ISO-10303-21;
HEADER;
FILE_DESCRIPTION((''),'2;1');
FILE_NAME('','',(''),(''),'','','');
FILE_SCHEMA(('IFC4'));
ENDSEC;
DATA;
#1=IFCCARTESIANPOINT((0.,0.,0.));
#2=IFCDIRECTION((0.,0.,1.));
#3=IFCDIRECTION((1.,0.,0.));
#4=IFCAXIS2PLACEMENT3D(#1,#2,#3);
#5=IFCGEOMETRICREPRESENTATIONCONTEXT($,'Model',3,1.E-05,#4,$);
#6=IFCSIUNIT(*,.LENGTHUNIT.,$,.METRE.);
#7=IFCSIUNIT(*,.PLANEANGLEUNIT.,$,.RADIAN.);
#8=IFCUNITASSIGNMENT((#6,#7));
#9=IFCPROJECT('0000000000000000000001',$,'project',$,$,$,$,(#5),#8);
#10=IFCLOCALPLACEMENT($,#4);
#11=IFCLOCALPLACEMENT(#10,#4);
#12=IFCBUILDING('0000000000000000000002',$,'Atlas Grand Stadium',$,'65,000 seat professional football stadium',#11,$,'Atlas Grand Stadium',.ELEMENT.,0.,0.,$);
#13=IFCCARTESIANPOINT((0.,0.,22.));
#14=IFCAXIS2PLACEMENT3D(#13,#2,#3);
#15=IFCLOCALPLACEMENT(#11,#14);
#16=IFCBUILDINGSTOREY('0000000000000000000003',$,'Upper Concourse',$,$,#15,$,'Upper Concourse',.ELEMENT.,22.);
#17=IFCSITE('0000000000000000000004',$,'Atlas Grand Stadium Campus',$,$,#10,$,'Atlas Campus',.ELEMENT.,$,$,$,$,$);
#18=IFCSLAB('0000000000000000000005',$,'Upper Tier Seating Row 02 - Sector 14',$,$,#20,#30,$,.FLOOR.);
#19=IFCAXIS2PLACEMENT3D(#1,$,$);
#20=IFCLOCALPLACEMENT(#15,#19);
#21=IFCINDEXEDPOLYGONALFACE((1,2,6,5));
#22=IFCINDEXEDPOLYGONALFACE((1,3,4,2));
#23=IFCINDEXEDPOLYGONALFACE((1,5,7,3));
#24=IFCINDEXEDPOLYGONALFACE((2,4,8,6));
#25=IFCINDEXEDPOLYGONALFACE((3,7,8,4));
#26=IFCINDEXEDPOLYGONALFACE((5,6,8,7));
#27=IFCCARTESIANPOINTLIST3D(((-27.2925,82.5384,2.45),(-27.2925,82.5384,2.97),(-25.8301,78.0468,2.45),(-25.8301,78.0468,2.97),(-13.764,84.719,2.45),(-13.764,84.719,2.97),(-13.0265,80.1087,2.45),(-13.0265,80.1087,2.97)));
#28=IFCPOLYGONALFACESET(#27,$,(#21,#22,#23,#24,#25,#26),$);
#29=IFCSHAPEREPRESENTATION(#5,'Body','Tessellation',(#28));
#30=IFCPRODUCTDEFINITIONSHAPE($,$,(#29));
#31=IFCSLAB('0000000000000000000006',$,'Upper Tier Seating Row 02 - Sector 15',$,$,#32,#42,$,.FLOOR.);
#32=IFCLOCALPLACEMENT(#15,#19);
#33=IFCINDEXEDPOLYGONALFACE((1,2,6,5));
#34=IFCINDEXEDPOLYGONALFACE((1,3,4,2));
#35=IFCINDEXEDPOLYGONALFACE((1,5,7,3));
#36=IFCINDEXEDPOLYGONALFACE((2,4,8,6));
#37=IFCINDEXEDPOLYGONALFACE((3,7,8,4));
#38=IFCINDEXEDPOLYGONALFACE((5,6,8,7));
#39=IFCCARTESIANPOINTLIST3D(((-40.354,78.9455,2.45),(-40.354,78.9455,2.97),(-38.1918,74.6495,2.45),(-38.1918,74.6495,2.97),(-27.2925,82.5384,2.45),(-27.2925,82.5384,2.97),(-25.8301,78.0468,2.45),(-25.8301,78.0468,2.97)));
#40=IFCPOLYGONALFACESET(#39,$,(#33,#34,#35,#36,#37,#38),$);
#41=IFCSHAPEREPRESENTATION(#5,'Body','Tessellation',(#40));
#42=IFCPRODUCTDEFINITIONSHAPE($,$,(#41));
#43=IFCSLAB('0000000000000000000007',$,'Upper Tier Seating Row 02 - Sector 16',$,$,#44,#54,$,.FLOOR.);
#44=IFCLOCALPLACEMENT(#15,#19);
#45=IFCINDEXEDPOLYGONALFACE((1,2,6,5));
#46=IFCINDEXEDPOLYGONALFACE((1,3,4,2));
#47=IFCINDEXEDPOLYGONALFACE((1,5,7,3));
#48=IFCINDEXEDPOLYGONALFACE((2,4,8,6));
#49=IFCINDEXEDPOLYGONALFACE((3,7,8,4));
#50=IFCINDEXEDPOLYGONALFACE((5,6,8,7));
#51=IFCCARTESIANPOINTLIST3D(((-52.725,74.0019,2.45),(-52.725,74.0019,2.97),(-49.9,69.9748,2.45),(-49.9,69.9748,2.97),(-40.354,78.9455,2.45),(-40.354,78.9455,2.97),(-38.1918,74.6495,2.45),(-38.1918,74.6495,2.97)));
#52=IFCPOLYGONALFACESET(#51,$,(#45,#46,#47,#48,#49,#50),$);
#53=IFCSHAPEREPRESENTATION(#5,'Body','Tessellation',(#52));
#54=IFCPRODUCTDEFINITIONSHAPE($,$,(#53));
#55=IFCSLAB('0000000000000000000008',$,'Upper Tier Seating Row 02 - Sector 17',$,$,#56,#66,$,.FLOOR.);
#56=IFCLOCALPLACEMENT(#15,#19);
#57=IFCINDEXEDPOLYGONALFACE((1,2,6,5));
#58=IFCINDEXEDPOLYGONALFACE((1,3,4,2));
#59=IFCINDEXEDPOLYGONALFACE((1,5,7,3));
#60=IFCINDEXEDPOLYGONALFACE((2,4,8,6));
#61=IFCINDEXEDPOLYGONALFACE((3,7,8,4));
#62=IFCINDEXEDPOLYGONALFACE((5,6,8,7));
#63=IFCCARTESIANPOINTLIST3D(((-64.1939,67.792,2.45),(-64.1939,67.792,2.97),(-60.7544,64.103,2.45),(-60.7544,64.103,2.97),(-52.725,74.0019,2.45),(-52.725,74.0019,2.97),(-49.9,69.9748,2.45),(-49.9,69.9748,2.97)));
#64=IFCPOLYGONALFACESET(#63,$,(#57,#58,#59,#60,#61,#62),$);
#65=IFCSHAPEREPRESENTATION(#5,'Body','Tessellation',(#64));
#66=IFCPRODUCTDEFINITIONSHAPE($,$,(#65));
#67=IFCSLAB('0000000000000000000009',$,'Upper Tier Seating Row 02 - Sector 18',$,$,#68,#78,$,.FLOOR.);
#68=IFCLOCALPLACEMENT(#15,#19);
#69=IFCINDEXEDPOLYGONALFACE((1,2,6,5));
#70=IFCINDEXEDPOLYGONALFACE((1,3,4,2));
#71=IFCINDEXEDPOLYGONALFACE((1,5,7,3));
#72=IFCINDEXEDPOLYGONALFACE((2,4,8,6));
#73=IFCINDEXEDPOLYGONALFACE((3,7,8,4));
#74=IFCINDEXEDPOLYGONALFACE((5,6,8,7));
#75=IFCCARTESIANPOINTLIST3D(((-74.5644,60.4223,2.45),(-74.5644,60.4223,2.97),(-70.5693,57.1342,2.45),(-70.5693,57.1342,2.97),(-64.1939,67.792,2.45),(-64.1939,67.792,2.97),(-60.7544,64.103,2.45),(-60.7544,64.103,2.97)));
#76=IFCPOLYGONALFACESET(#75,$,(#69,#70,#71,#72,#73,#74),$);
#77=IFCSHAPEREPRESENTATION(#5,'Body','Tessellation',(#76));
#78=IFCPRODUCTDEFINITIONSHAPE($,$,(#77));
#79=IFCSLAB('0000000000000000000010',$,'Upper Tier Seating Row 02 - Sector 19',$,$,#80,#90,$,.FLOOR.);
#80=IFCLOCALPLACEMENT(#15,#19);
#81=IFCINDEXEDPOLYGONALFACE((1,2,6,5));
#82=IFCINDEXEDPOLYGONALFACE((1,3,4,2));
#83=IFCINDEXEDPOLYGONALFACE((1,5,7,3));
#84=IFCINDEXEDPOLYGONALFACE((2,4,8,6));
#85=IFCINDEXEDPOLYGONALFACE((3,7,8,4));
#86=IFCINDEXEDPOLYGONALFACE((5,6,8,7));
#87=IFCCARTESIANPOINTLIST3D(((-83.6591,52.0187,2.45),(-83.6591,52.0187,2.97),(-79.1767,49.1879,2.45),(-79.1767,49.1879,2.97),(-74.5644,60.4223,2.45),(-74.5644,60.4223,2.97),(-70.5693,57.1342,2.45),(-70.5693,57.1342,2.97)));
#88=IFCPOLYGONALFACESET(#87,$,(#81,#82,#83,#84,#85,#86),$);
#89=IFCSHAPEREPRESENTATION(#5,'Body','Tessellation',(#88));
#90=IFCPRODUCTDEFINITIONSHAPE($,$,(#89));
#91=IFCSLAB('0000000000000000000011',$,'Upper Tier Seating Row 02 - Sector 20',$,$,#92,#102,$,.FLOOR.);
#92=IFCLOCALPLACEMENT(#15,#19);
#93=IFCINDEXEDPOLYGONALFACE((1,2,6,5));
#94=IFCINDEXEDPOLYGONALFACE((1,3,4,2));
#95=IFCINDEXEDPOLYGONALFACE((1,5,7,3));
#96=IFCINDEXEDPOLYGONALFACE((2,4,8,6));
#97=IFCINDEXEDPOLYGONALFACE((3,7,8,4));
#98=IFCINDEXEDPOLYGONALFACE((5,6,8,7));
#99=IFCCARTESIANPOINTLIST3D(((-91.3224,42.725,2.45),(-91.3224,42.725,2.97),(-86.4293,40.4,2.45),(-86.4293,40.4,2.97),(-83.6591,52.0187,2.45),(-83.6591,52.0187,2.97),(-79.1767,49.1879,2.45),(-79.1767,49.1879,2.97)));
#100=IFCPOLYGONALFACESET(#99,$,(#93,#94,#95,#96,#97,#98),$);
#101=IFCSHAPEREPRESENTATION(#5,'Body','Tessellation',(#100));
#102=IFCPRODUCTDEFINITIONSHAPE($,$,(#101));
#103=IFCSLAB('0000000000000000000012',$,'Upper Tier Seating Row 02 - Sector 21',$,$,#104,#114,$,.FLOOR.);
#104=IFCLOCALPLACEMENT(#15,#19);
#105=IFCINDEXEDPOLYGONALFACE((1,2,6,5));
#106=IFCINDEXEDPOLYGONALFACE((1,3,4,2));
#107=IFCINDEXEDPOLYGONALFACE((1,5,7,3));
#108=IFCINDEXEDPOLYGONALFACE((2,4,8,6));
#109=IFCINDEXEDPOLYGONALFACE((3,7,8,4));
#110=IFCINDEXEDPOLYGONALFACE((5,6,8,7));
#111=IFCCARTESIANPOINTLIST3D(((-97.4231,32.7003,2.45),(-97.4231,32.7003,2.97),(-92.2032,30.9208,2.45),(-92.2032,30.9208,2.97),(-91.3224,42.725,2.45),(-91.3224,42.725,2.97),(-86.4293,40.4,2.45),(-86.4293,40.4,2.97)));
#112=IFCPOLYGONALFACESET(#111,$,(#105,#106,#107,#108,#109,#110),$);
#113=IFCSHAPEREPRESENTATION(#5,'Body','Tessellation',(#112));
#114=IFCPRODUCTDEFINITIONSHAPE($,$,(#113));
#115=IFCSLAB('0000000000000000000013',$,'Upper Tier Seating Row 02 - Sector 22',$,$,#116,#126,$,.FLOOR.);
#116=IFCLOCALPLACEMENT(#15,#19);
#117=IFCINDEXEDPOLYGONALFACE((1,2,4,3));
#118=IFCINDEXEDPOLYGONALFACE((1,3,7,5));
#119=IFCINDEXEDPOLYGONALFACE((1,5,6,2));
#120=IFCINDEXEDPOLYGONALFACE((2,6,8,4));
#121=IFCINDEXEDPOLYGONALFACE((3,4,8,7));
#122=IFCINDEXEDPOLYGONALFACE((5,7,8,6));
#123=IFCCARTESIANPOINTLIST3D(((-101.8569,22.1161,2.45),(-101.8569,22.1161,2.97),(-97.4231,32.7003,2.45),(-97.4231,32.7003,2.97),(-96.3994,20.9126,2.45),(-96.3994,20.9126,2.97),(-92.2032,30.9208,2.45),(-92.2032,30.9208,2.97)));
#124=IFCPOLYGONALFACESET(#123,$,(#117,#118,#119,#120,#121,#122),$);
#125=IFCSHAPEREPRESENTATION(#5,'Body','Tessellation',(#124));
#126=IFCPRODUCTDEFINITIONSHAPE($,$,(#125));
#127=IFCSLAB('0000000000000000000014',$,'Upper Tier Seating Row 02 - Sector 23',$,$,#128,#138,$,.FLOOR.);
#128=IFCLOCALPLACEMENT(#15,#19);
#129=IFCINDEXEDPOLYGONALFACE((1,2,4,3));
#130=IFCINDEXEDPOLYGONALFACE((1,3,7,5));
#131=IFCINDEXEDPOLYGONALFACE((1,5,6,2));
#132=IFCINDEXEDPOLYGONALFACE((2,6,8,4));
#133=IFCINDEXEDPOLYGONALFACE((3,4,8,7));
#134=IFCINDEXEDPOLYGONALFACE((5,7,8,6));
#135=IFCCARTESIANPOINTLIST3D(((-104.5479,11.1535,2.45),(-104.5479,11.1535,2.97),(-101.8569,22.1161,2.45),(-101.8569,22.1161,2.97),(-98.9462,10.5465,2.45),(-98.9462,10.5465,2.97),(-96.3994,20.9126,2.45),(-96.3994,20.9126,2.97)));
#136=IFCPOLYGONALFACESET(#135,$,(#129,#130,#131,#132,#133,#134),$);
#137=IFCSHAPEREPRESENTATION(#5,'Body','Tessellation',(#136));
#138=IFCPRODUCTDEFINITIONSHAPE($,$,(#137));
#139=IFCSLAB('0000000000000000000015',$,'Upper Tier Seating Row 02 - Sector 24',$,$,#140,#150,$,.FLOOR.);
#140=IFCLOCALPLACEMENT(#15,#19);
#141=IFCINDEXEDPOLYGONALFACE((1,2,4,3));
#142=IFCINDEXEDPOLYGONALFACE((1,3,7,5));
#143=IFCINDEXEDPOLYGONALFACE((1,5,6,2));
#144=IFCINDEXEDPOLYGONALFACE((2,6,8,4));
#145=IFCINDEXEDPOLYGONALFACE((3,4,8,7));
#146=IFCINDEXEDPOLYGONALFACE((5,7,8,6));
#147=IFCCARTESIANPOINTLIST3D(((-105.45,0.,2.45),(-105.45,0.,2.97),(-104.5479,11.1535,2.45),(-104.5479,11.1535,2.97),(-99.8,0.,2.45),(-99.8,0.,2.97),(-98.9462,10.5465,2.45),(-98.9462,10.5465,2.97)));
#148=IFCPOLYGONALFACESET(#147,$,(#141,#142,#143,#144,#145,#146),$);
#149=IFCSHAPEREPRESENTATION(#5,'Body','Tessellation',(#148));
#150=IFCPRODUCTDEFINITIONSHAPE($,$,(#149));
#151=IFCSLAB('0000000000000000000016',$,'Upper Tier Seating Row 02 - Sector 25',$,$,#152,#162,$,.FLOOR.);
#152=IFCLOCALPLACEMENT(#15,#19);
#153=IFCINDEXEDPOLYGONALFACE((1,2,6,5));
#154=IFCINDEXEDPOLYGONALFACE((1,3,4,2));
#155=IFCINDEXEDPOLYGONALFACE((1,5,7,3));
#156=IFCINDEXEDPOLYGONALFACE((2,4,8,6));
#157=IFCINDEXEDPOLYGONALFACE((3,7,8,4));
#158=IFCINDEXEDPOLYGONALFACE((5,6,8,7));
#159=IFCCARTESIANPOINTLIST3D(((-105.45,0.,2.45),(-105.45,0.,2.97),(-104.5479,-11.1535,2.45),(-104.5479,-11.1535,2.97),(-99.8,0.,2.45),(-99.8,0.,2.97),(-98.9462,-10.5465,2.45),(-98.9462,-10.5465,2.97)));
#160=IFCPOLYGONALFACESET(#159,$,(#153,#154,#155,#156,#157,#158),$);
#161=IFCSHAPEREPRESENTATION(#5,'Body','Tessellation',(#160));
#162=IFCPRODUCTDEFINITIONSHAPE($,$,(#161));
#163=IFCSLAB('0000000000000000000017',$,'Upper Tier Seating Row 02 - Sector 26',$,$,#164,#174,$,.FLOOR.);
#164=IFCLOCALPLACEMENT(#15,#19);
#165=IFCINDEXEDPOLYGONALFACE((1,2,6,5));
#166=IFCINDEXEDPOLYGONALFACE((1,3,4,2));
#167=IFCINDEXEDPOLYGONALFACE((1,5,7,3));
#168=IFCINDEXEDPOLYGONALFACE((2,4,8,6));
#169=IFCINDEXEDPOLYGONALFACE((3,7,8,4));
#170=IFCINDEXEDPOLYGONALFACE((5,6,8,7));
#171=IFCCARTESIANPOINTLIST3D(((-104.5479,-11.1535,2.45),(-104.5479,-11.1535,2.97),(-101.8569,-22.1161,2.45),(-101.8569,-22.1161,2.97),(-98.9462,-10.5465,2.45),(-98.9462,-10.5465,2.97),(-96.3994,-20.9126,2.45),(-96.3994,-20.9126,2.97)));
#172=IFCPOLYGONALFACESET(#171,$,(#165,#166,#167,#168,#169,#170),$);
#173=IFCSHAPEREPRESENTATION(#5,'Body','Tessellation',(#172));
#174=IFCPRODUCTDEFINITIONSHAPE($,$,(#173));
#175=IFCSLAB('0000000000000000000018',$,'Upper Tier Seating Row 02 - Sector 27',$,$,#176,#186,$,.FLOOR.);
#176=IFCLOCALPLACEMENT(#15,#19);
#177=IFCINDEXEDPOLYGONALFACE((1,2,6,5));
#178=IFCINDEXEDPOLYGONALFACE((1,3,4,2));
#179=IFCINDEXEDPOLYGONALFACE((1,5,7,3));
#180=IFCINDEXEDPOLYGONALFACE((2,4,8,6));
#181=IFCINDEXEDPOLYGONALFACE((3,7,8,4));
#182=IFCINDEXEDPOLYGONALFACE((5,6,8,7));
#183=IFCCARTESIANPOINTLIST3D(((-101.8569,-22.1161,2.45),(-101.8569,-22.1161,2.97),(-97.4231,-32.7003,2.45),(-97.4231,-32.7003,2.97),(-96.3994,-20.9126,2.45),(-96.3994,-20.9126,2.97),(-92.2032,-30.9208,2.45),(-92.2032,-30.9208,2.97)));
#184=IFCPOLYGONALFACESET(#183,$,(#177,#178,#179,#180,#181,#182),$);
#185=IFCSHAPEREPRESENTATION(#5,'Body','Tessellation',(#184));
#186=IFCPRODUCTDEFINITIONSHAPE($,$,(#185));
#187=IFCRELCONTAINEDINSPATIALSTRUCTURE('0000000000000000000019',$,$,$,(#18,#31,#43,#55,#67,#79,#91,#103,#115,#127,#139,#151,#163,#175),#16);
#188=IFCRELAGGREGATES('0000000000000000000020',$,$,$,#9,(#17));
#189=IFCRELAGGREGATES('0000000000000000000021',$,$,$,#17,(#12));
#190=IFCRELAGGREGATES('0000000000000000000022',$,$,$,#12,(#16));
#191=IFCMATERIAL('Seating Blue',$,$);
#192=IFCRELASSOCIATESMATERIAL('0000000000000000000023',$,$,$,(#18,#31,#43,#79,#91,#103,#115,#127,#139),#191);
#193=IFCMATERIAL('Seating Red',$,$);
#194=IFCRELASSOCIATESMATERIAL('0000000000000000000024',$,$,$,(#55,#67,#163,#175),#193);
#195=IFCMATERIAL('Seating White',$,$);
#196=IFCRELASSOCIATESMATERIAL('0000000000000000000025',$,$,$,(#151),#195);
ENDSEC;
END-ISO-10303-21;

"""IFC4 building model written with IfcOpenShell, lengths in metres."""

from ifc_helpers import new_model, si_unit, frame, origin_with_axes, place, context, project, spatial, polyline, outline, extrude, material, element, save


model = new_model("IFC4")

# Units and contexts
model_context = context("Model", 3, precision=1e-05, world=origin_with_axes())
ifc_project = project(units=[si_unit("LENGTHUNIT", "METRE"), si_unit("PLANEANGLEUNIT", "RADIAN")], contexts=[model_context])

# Site, building, storey
site_placement = place(None, origin_with_axes())
site = spatial("IfcSite", under=ifc_project, at=site_placement, Name="Atlas Grand Stadium Campus", LongName="Atlas Campus", CompositionType="ELEMENT")
building_placement = place(site_placement, origin_with_axes())
building = spatial("IfcBuilding", under=site, at=building_placement, Name="Atlas Grand Stadium", ObjectType="65,000 seat professional football stadium", LongName="Atlas Grand Stadium", CompositionType="ELEMENT", ElevationOfRefHeight=0.0, ElevationOfTerrain=0.0)
storey_placement = place(building_placement, frame((0.0, 0.0, 22.0), z_axis=(0.0, 0.0, 1.0), x_axis=(1.0, 0.0, 0.0)))
storey = spatial("IfcBuildingStorey", under=building, at=storey_placement, Name="Upper Concourse", LongName="Upper Concourse", CompositionType="ELEMENT", Elevation=22.0)

# Slabs
ifc_material_1 = material(Name="Seating Blue")
slab_1_placement = place(storey_placement, frame((0.0, 0.0, 2.45), z_axis=(0.0, 0.0, 1.0), x_axis=(1.0, 0.0, 0.0)))
element("IfcSlab", 1, at=slab_1_placement, inside=storey, material=ifc_material_1, Name="Upper Tier Seating Row 02 - Sector 14", PredefinedType="FLOOR", context=model_context, shape_type="SweptSolid", body=[
    extrude(outline(polyline([(-13.764, 84.719), (-27.2925, 82.5384), (-25.8301, 78.0468), (-13.0265, 80.1087), (-13.764, 84.719)])), origin_with_axes(), (0.0, 0.0, 1.0), 0.52),
])
slab_2_placement = place(storey_placement, frame((0.0, 0.0, 2.45), z_axis=(0.0, 0.0, 1.0), x_axis=(1.0, 0.0, 0.0)))
element("IfcSlab", 2, at=slab_2_placement, inside=storey, material=ifc_material_1, Name="Upper Tier Seating Row 02 - Sector 15", PredefinedType="FLOOR", context=model_context, shape_type="SweptSolid", body=[
    extrude(outline(polyline([(-27.2925, 82.5384), (-40.354, 78.9455), (-38.1918, 74.6495), (-25.8301, 78.0468), (-27.2925, 82.5384)])), origin_with_axes(), (0.0, 0.0, 1.0), 0.52),
])
slab_3_placement = place(storey_placement, frame((0.0, 0.0, 2.45), z_axis=(0.0, 0.0, 1.0), x_axis=(1.0, 0.0, 0.0)))
element("IfcSlab", 3, at=slab_3_placement, inside=storey, material=ifc_material_1, Name="Upper Tier Seating Row 02 - Sector 16", PredefinedType="FLOOR", context=model_context, shape_type="SweptSolid", body=[
    extrude(outline(polyline([(-40.354, 78.9455), (-52.725, 74.0019), (-49.9, 69.9749), (-38.1918, 74.6495), (-40.354, 78.9455)])), origin_with_axes(), (0.0, 0.0, 1.0), 0.52),
])
ifc_material_2 = material(Name="Seating Red")
slab_4_placement = place(storey_placement, frame((0.0, 0.0, 2.45), z_axis=(0.0, 0.0, 1.0), x_axis=(1.0, 0.0, 0.0)))
element("IfcSlab", 4, at=slab_4_placement, inside=storey, material=ifc_material_2, Name="Upper Tier Seating Row 02 - Sector 17", PredefinedType="FLOOR", context=model_context, shape_type="SweptSolid", body=[
    extrude(outline(polyline([(-52.725, 74.0019), (-64.1939, 67.792), (-60.7544, 64.103), (-49.9, 69.9749), (-52.725, 74.0019)])), origin_with_axes(), (0.0, 0.0, 1.0), 0.52),
])
slab_5_placement = place(storey_placement, frame((0.0, 0.0, 2.45), z_axis=(0.0, 0.0, 1.0), x_axis=(1.0, 0.0, 0.0)))
element("IfcSlab", 5, at=slab_5_placement, inside=storey, material=ifc_material_2, Name="Upper Tier Seating Row 02 - Sector 18", PredefinedType="FLOOR", context=model_context, shape_type="SweptSolid", body=[
    extrude(outline(polyline([(-64.1939, 67.792), (-74.5644, 60.4223), (-70.5693, 57.1342), (-60.7544, 64.103), (-64.1939, 67.792)])), origin_with_axes(), (0.0, 0.0, 1.0), 0.52),
])
slab_6_placement = place(storey_placement, frame((0.0, 0.0, 2.45), z_axis=(0.0, 0.0, 1.0), x_axis=(1.0, 0.0, 0.0)))
element("IfcSlab", 6, at=slab_6_placement, inside=storey, material=ifc_material_1, Name="Upper Tier Seating Row 02 - Sector 19", PredefinedType="FLOOR", context=model_context, shape_type="SweptSolid", body=[
    extrude(outline(polyline([(-74.5644, 60.4223), (-83.6591, 52.0187), (-79.1767, 49.1879), (-70.5693, 57.1342), (-74.5644, 60.4223)])), origin_with_axes(), (0.0, 0.0, 1.0), 0.52),
])
slab_7_placement = place(storey_placement, frame((0.0, 0.0, 2.45), z_axis=(0.0, 0.0, 1.0), x_axis=(1.0, 0.0, 0.0)))
element("IfcSlab", 7, at=slab_7_placement, inside=storey, material=ifc_material_1, Name="Upper Tier Seating Row 02 - Sector 20", PredefinedType="FLOOR", context=model_context, shape_type="SweptSolid", body=[
    extrude(outline(polyline([(-83.6591, 52.0187), (-91.3224, 42.725), (-86.4293, 40.4), (-79.1767, 49.1879), (-83.6591, 52.0187)])), origin_with_axes(), (0.0, 0.0, 1.0), 0.52),
])
slab_8_placement = place(storey_placement, frame((0.0, 0.0, 2.45), z_axis=(0.0, 0.0, 1.0), x_axis=(1.0, 0.0, 0.0)))
element("IfcSlab", 8, at=slab_8_placement, inside=storey, material=ifc_material_1, Name="Upper Tier Seating Row 02 - Sector 21", PredefinedType="FLOOR", context=model_context, shape_type="SweptSolid", body=[
    extrude(outline(polyline([(-91.3224, 42.725), (-97.4231, 32.7003), (-92.2032, 30.9208), (-86.4293, 40.4), (-91.3224, 42.725)])), origin_with_axes(), (0.0, 0.0, 1.0), 0.52),
])
slab_9_placement = place(storey_placement, frame((0.0, 0.0, 2.45), z_axis=(0.0, 0.0, 1.0), x_axis=(1.0, 0.0, 0.0)))
element("IfcSlab", 9, at=slab_9_placement, inside=storey, material=ifc_material_1, Name="Upper Tier Seating Row 02 - Sector 22", PredefinedType="FLOOR", context=model_context, shape_type="SweptSolid", body=[
    extrude(outline(polyline([(-97.4231, 32.7003), (-101.8569, 22.1161), (-96.3994, 20.9126), (-92.2032, 30.9208), (-97.4231, 32.7003)])), origin_with_axes(), (0.0, 0.0, 1.0), 0.52),
])
slab_10_placement = place(storey_placement, frame((0.0, 0.0, 2.45), z_axis=(0.0, 0.0, 1.0), x_axis=(1.0, 0.0, 0.0)))
element("IfcSlab", 10, at=slab_10_placement, inside=storey, material=ifc_material_1, Name="Upper Tier Seating Row 02 - Sector 23", PredefinedType="FLOOR", context=model_context, shape_type="SweptSolid", body=[
    extrude(outline(polyline([(-101.8569, 22.1161), (-104.5479, 11.1535), (-98.9462, 10.5465), (-96.3994, 20.9126), (-101.8569, 22.1161)])), origin_with_axes(), (0.0, 0.0, 1.0), 0.52),
])
slab_11_placement = place(storey_placement, frame((0.0, 0.0, 2.45), z_axis=(0.0, 0.0, 1.0), x_axis=(1.0, 0.0, 0.0)))
element("IfcSlab", 11, at=slab_11_placement, inside=storey, material=ifc_material_1, Name="Upper Tier Seating Row 02 - Sector 24", PredefinedType="FLOOR", context=model_context, shape_type="SweptSolid", body=[
    extrude(outline(polyline([(-104.5479, 11.1535), (-105.45, 0.0), (-99.8, 0.0), (-98.9462, 10.5465), (-104.5479, 11.1535)])), origin_with_axes(), (0.0, 0.0, 1.0), 0.52),
])
ifc_material_3 = material(Name="Seating White")
slab_12_placement = place(storey_placement, frame((0.0, 0.0, 2.45), z_axis=(0.0, 0.0, 1.0), x_axis=(1.0, 0.0, 0.0)))
element("IfcSlab", 12, at=slab_12_placement, inside=storey, material=ifc_material_3, Name="Upper Tier Seating Row 02 - Sector 25", PredefinedType="FLOOR", context=model_context, shape_type="SweptSolid", body=[
    extrude(outline(polyline([(-105.45, 0.0), (-104.5479, -11.1535), (-98.9462, -10.5465), (-99.8, 0.0), (-105.45, 0.0)])), origin_with_axes(), (0.0, 0.0, 1.0), 0.52),
])
slab_13_placement = place(storey_placement, frame((0.0, 0.0, 2.45), z_axis=(0.0, 0.0, 1.0), x_axis=(1.0, 0.0, 0.0)))
element("IfcSlab", 13, at=slab_13_placement, inside=storey, material=ifc_material_2, Name="Upper Tier Seating Row 02 - Sector 26", PredefinedType="FLOOR", context=model_context, shape_type="SweptSolid", body=[
    extrude(outline(polyline([(-104.5479, -11.1535), (-101.8569, -22.1161), (-96.3994, -20.9126), (-98.9462, -10.5465), (-104.5479, -11.1535)])), origin_with_axes(), (0.0, 0.0, 1.0), 0.52),
])
slab_14_placement = place(storey_placement, frame((0.0, 0.0, 2.45), z_axis=(0.0, 0.0, 1.0), x_axis=(1.0, 0.0, 0.0)))
element("IfcSlab", 14, at=slab_14_placement, inside=storey, material=ifc_material_2, Name="Upper Tier Seating Row 02 - Sector 27", PredefinedType="FLOOR", context=model_context, shape_type="SweptSolid", body=[
    extrude(outline(polyline([(-101.8569, -22.1161), (-97.4231, -32.7003), (-92.2032, -30.9208), (-96.3994, -20.9126), (-101.8569, -22.1161)])), origin_with_axes(), (0.0, 0.0, 1.0), 0.52),
])

save(model, "model.ifc")
